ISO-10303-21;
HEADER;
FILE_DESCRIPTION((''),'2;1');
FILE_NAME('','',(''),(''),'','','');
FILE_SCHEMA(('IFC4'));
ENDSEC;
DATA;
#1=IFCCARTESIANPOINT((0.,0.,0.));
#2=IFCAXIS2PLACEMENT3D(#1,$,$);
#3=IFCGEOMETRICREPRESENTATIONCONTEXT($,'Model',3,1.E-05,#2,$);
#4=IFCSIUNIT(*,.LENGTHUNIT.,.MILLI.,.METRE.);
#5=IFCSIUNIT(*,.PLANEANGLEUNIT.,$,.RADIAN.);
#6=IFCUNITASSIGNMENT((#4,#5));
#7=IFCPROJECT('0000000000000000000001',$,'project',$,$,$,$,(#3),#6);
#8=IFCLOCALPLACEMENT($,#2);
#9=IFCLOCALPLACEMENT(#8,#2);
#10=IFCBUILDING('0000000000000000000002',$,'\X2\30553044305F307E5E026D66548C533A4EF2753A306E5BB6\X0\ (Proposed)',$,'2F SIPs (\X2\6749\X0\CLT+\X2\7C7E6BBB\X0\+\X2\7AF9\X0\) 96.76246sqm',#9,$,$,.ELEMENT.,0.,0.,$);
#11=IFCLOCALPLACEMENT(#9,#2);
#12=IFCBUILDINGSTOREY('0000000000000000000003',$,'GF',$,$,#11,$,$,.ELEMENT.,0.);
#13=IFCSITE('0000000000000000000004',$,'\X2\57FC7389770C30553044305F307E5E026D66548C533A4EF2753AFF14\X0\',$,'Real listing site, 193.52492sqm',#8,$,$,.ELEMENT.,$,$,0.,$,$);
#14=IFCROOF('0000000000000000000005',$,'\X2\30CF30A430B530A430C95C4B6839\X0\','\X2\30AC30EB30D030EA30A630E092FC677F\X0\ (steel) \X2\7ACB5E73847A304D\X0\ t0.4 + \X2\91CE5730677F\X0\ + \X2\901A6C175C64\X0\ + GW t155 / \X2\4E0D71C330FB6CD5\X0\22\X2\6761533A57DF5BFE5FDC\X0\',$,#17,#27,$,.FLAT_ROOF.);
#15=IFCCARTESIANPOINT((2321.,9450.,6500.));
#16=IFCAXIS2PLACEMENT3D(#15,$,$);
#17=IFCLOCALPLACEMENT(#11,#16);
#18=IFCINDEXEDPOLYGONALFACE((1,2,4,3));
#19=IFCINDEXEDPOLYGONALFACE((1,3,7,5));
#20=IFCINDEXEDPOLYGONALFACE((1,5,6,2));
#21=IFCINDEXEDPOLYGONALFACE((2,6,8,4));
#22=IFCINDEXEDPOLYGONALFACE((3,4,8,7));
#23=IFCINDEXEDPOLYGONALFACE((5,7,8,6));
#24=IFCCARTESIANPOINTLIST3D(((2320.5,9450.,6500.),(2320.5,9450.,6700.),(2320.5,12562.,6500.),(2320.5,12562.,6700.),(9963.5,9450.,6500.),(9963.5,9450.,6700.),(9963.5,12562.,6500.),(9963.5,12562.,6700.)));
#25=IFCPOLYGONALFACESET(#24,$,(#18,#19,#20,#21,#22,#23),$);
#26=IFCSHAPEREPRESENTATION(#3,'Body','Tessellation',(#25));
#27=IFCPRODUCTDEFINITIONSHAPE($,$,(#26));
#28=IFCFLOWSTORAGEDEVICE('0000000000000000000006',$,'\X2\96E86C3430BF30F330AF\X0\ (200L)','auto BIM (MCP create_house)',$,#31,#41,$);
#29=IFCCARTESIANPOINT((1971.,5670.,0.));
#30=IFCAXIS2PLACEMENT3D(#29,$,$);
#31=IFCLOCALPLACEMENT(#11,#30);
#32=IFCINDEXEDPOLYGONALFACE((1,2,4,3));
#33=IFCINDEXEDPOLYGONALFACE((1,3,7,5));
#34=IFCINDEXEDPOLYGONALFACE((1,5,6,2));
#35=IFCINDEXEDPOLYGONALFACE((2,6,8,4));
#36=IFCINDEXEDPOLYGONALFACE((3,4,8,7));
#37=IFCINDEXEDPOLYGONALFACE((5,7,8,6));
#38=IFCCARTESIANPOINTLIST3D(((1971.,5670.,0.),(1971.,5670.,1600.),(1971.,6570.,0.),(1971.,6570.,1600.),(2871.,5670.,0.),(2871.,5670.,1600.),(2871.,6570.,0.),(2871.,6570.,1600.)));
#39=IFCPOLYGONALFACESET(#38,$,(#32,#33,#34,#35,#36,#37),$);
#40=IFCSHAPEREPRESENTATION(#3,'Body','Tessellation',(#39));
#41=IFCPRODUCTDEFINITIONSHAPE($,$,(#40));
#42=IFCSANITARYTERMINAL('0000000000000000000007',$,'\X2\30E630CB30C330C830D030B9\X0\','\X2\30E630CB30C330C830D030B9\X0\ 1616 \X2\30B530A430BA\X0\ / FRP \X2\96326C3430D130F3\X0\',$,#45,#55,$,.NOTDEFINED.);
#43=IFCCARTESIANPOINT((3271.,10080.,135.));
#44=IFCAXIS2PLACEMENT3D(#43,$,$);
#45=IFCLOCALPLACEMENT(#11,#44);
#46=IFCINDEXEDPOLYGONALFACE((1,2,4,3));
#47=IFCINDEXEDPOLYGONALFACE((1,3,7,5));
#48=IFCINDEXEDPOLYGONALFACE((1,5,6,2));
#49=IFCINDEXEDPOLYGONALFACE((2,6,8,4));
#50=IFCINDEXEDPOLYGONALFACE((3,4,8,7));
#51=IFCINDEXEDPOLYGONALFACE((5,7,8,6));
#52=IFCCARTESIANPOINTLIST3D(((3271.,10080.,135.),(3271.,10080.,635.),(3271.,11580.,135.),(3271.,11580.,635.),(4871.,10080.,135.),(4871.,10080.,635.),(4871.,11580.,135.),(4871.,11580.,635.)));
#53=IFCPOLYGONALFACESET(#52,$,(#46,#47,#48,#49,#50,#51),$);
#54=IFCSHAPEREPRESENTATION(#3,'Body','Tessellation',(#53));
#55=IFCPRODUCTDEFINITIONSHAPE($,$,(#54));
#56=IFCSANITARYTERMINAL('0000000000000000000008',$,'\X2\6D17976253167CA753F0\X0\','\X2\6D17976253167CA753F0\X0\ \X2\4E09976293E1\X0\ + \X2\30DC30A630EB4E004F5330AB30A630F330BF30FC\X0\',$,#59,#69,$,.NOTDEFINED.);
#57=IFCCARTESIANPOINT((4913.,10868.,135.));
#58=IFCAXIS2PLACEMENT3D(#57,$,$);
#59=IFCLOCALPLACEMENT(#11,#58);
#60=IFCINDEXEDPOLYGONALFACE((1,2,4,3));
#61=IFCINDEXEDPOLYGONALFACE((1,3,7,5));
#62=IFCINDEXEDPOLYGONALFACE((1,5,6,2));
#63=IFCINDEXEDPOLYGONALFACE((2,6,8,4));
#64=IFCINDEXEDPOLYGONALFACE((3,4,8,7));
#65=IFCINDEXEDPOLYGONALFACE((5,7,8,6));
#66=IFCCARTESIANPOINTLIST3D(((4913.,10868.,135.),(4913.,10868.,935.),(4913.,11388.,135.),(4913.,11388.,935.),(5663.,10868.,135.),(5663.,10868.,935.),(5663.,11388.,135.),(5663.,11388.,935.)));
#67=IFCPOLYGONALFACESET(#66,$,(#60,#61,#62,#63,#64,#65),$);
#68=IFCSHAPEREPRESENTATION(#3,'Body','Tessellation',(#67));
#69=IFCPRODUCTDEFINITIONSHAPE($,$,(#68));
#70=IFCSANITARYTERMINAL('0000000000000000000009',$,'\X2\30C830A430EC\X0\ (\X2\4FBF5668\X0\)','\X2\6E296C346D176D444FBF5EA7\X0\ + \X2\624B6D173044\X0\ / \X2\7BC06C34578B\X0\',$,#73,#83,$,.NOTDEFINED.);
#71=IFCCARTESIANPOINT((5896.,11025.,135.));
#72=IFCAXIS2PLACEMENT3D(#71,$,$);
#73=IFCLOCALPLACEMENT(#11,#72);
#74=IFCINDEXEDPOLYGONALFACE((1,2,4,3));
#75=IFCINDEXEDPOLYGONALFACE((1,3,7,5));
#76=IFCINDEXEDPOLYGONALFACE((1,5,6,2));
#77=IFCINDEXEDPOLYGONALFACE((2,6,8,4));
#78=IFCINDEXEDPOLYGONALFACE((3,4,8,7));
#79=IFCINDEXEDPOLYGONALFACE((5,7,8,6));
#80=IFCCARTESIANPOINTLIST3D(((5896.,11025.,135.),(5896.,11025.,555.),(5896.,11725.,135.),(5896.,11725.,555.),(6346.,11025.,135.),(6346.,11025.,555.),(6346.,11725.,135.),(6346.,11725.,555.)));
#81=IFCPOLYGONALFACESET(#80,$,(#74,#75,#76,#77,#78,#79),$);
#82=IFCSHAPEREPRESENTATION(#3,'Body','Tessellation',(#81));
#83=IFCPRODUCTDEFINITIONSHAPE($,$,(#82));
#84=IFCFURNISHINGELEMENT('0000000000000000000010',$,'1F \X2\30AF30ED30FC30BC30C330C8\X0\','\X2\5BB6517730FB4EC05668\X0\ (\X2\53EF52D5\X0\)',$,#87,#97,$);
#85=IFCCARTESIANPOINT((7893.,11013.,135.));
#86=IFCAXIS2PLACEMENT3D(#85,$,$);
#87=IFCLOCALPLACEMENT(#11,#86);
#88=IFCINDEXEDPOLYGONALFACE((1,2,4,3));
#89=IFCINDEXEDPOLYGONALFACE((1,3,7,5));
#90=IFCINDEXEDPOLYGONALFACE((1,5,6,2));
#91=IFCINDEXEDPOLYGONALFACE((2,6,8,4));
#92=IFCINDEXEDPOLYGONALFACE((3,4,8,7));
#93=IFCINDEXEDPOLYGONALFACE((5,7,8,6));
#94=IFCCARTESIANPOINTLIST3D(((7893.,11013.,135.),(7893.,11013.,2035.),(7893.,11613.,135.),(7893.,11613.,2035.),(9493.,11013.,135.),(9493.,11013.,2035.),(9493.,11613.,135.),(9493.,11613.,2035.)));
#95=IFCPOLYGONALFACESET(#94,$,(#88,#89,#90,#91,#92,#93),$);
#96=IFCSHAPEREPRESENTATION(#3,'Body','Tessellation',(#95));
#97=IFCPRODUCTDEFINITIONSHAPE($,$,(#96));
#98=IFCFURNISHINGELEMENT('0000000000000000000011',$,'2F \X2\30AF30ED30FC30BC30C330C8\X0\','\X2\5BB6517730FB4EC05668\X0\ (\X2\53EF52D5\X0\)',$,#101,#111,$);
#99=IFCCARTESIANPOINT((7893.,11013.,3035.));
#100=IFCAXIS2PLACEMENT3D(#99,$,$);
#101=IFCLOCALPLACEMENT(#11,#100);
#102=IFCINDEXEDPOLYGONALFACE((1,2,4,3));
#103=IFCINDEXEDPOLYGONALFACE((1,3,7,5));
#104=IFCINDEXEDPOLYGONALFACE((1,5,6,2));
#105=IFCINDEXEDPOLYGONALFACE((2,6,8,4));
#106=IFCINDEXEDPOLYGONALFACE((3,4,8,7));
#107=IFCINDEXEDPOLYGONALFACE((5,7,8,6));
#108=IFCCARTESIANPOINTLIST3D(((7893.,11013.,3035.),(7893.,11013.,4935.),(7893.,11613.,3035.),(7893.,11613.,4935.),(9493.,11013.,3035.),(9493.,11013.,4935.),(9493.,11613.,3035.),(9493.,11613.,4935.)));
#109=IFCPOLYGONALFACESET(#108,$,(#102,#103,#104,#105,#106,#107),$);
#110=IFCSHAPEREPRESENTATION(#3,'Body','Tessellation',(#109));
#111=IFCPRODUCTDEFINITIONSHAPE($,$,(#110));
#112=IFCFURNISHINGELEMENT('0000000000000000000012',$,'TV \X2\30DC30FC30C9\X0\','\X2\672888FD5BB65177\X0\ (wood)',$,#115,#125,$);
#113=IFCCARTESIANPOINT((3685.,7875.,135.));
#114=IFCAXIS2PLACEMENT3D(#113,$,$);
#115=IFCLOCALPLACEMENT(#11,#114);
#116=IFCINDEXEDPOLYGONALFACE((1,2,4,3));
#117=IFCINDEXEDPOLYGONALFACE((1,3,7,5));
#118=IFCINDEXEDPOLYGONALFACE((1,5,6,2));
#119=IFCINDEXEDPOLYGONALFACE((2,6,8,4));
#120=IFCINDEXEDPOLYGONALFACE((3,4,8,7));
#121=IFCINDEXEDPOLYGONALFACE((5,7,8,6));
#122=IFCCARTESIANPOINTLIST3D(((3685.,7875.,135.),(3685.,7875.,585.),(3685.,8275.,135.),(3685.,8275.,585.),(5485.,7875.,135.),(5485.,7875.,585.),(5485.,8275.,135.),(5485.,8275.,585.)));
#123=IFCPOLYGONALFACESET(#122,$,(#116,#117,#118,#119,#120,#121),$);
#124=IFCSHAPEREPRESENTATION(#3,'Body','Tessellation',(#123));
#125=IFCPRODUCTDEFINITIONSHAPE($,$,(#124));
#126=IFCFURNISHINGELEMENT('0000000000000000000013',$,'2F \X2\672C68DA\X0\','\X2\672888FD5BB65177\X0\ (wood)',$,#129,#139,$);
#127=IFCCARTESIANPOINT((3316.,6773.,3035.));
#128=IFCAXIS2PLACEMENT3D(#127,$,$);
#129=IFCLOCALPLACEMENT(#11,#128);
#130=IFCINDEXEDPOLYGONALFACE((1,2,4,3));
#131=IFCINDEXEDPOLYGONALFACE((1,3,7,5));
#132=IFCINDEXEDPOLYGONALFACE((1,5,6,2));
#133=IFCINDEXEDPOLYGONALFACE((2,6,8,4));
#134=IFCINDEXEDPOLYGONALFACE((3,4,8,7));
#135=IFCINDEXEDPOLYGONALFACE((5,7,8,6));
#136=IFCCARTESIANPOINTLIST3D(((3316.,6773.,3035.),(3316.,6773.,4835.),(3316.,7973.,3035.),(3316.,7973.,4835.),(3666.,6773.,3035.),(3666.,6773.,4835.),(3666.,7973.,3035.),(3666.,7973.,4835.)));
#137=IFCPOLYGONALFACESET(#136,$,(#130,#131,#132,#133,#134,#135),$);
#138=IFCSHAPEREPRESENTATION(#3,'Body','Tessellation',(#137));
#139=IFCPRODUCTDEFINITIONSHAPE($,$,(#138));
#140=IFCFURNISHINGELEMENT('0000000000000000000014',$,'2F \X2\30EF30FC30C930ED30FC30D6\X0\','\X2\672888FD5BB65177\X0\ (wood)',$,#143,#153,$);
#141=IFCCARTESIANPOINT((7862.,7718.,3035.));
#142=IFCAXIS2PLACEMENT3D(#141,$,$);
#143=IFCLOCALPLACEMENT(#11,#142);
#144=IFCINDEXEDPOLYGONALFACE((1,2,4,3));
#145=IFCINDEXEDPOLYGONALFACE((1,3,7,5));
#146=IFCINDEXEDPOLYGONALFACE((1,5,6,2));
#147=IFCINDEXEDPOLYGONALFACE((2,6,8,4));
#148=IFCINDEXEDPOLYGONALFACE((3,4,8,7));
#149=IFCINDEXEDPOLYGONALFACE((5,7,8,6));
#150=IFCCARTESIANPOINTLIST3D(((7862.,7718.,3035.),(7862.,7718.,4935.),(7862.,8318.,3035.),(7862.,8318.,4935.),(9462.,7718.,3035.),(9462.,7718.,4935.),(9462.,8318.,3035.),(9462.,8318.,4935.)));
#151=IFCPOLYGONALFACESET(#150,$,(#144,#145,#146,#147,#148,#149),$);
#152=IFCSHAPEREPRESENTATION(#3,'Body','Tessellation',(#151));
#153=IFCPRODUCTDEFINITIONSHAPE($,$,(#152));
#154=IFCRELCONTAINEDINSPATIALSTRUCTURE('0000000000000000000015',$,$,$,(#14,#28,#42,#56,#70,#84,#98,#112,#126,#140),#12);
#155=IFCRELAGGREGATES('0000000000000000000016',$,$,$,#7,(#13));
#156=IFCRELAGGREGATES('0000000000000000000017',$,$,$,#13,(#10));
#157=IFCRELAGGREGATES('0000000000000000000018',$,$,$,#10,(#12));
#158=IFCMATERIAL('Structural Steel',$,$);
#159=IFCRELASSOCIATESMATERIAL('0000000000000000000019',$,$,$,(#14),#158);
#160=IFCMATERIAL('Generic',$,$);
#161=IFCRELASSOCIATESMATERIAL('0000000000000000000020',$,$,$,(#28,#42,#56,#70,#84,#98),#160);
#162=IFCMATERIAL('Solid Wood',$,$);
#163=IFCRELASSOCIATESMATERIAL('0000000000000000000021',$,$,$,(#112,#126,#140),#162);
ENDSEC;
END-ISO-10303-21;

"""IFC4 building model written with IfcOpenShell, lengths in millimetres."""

from ifc_helpers import new_model, si_unit, frame, frame_2d, origin, place, context, project, spatial, rectangle, extrude, material, element, save


model = new_model("IFC4")

# Units and contexts
model_context = context("Model", 3, precision=1e-05, world=origin())
ifc_project = project(units=[si_unit("LENGTHUNIT", "METRE", prefix="MILLI"), si_unit("PLANEANGLEUNIT", "RADIAN")], contexts=[model_context])

# Site, building, storey
site_placement = place(None, origin())
site = spatial("IfcSite", under=ifc_project, at=site_placement, Name="埼玉県さいたま市浦和区仲町４", ObjectType="Real listing site, 193.52492sqm", CompositionType="ELEMENT", RefElevation=0.0)
building_placement = place(site_placement, origin())
building = spatial("IfcBuilding", under=site, at=building_placement, Name="さいたま市浦和区仲町の家 (Proposed)", ObjectType="2F SIPs (杉CLT+籾殻+竹) 96.76246sqm", CompositionType="ELEMENT", ElevationOfRefHeight=0.0, ElevationOfTerrain=0.0)
storey_placement = place(building_placement, origin())
storey = spatial("IfcBuildingStorey", under=building, at=storey_placement, Name="GF", CompositionType="ELEMENT", Elevation=0.0)

# Shared definitions
ifc_material_1 = material(Name="Solid Wood")

# Roof
ifc_material_2 = material(Name="Structural Steel")
roof_placement = place(storey_placement, frame((2321.0, 9450.0, 6500.0)))
element("IfcRoof", 1, at=roof_placement, inside=storey, material=ifc_material_2, Name="ハイサイド屋根", Description="ガルバリウム鋼板 (steel) 立平葺き t0.4 + 野地板 + 通気層 + GW t155 / 不燃・法22条区域対応", PredefinedType="FLAT_ROOF", context=model_context, shape_type="SweptSolid", body=[
    extrude(rectangle(XDim=7643.0, YDim=3112.0, at=frame_2d((3821.0, 1556.0))), frame((2321.0, 9450.0, 6500.0)), (0.0, 0.0, 1.0), 200.0),
])

# Flow storage device
ifc_material_3 = material(Name="Generic")
flow_storage_device_placement = place(storey_placement, frame((1971.0, 5670.0, 0.0)))
element("IfcFlowStorageDevice", 2, at=flow_storage_device_placement, inside=storey, material=ifc_material_3, Name="雨水タンク (200L)", Description="auto BIM (MCP create_house)", context=model_context, shape_type="SweptSolid", body=[
    extrude(rectangle(XDim=900.0, YDim=900.0, at=frame_2d((450.0, 450.0))), frame((1971.0, 5670.0, 0.0)), (0.0, 0.0, 1.0), 1600.0),
])

# Sanitary terminals
sanitary_terminal_1_placement = place(storey_placement, frame((3271.0, 10080.0, 135.0)))
element("IfcSanitaryTerminal", 3, at=sanitary_terminal_1_placement, inside=storey, material=ifc_material_3, Name="ユニットバス", Description="ユニットバス 1616 サイズ / FRP 防水パン", PredefinedType="NOTDEFINED", context=model_context, shape_type="SweptSolid", body=[
    extrude(rectangle(XDim=1600.0, YDim=1500.0, at=frame_2d((800.0, 750.0))), frame((3271.0, 10080.0, 135.0)), (0.0, 0.0, 1.0), 500.0),
])
sanitary_terminal_2_placement = place(storey_placement, frame((4913.0, 10868.0, 135.0)))
element("IfcSanitaryTerminal", 4, at=sanitary_terminal_2_placement, inside=storey, material=ifc_material_3, Name="洗面化粧台", Description="洗面化粧台 三面鏡 + ボウル一体カウンター", PredefinedType="NOTDEFINED", context=model_context, shape_type="SweptSolid", body=[
    extrude(rectangle(XDim=750.0, YDim=520.0, at=frame_2d((375.0, 260.0))), frame((4913.0, 10868.0, 135.0)), (0.0, 0.0, 1.0), 800.0),
])
sanitary_terminal_3_placement = place(storey_placement, frame((5896.0, 11025.0, 135.0)))
element("IfcSanitaryTerminal", 5, at=sanitary_terminal_3_placement, inside=storey, material=ifc_material_3, Name="トイレ (便器)", Description="温水洗浄便座 + 手洗い / 節水型", PredefinedType="NOTDEFINED", context=model_context, shape_type="SweptSolid", body=[
    extrude(rectangle(XDim=450.0, YDim=700.0, at=frame_2d((225.0, 350.0))), frame((5896.0, 11025.0, 135.0)), (0.0, 0.0, 1.0), 420.0),
])

# Furnishing elements
furnishing_1_placement = place(storey_placement, frame((7893.0, 11013.0, 135.0)))
element("IfcFurnishingElement", 6, at=furnishing_1_placement, inside=storey, material=ifc_material_3, Name="1F クローゼット", Description="家具・什器 (可動)", context=model_context, shape_type="SweptSolid", body=[
    extrude(rectangle(XDim=1600.0, YDim=600.0, at=frame_2d((800.0, 300.0))), frame((7893.0, 11013.0, 135.0)), (0.0, 0.0, 1.0), 1900.0),
])
furnishing_2_placement = place(storey_placement, frame((7893.0, 11013.0, 3035.0)))
element("IfcFurnishingElement", 7, at=furnishing_2_placement, inside=storey, material=ifc_material_3, Name="2F クローゼット", Description="家具・什器 (可動)", context=model_context, shape_type="SweptSolid", body=[
    extrude(rectangle(XDim=1600.0, YDim=600.0, at=frame_2d((800.0, 300.0))), frame((7893.0, 11013.0, 3035.0)), (0.0, 0.0, 1.0), 1900.0),
])
furnishing_3_placement = place(storey_placement, frame((3685.0, 7875.0, 135.0)))
element("IfcFurnishingElement", 8, at=furnishing_3_placement, inside=storey, material=ifc_material_1, Name="TV ボード", Description="木製家具 (wood)", context=model_context, shape_type="SweptSolid", body=[
    extrude(rectangle(XDim=1800.0, YDim=400.0, at=frame_2d((900.0, 200.0))), frame((3685.0, 7875.0, 135.0)), (0.0, 0.0, 1.0), 450.0),
])
furnishing_4_placement = place(storey_placement, frame((3316.0, 6773.0, 3035.0)))
element("IfcFurnishingElement", 9, at=furnishing_4_placement, inside=storey, material=ifc_material_1, Name="2F 本棚", Description="木製家具 (wood)", context=model_context, shape_type="SweptSolid", body=[
    extrude(rectangle(XDim=350.0, YDim=1200.0, at=frame_2d((175.0, 600.0))), frame((3316.0, 6773.0, 3035.0)), (0.0, 0.0, 1.0), 1800.0),
])
furnishing_5_placement = place(storey_placement, frame((7862.0, 7718.0, 3035.0)))
element("IfcFurnishingElement", 10, at=furnishing_5_placement, inside=storey, material=ifc_material_1, Name="2F ワードローブ", Description="木製家具 (wood)", context=model_context, shape_type="SweptSolid", body=[
    extrude(rectangle(XDim=1600.0, YDim=600.0, at=frame_2d((800.0, 300.0))), frame((7862.0, 7718.0, 3035.0)), (0.0, 0.0, 1.0), 1900.0),
])

save(model, "model.ifc")
